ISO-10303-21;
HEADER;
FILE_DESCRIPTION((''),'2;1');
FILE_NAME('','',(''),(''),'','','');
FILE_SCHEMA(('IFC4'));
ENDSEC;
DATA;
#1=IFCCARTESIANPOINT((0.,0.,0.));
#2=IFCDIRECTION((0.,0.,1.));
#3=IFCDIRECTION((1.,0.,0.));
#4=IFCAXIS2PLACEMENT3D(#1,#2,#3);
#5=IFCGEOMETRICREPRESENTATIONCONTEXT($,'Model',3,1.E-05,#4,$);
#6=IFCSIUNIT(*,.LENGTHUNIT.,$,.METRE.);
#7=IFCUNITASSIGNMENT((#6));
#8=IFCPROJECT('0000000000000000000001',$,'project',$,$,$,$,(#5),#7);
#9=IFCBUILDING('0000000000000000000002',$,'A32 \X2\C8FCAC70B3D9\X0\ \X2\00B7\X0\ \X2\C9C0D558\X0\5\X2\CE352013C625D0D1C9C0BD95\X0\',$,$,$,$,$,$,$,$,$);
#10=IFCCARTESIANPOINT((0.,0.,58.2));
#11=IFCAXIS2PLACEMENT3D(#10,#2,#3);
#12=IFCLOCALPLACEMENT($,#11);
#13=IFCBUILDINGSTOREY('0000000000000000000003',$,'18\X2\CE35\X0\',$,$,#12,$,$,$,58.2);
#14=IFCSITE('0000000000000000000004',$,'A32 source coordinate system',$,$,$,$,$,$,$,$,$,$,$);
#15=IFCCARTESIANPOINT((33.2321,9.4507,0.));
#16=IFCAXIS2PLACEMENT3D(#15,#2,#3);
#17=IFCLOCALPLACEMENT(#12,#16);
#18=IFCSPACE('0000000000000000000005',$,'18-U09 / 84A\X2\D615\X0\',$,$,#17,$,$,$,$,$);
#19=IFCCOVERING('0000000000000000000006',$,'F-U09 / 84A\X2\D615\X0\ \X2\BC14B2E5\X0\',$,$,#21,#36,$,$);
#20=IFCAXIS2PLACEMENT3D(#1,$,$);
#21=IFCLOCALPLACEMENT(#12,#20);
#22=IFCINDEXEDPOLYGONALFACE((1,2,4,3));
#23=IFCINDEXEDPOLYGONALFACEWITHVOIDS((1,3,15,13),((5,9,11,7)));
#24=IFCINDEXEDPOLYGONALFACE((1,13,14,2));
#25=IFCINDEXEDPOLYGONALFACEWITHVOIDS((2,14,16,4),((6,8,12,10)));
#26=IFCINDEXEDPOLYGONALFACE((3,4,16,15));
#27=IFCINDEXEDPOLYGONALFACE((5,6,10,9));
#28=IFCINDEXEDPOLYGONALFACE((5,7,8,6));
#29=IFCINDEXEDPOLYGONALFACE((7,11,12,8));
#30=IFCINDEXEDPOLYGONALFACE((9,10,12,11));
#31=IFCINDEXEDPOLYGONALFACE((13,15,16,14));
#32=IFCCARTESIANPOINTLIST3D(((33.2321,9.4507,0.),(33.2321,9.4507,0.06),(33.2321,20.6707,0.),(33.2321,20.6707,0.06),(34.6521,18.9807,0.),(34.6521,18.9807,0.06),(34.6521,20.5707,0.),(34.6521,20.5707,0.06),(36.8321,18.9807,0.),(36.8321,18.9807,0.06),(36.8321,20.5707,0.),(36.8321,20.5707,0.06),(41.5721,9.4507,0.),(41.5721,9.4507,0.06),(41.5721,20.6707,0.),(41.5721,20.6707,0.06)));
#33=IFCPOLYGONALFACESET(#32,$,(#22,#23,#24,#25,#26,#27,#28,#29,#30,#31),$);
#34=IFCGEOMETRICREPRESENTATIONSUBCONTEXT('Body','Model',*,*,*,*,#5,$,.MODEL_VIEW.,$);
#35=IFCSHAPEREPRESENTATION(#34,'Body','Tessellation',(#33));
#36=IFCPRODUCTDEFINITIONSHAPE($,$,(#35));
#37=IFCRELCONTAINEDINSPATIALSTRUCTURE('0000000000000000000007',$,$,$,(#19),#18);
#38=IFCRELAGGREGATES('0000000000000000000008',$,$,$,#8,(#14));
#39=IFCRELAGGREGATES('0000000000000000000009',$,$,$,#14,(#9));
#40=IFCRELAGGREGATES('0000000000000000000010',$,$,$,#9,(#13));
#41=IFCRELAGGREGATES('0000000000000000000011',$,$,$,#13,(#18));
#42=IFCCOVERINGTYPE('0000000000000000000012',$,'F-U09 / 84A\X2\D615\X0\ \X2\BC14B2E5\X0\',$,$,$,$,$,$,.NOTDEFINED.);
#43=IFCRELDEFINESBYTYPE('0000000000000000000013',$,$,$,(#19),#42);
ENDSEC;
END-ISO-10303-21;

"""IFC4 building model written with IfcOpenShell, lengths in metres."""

from ifc_helpers import new_model, si_unit, frame, origin, origin_with_axes, place, context, subcontext, project, spatial, polyline, outline, extrude, source, transform, mapped, type_object, type_shapes, element, save


model = new_model("IFC4")

# Units and contexts
model_context = context("Model", 3, precision=1e-05, world=origin_with_axes())
body_context = subcontext(model_context, "Body", "Model", "MODEL_VIEW")
ifc_project = project(units=[si_unit("LENGTHUNIT", "METRE")], contexts=[model_context])

# Site, building, storey, space
storey_placement = place(None, frame((0.0, 0.0, 58.2), z_axis=(0.0, 0.0, 1.0), x_axis=(1.0, 0.0, 0.0)))
space_placement = place(storey_placement, frame((33.2321, 9.4507, 0.0), z_axis=(0.0, 0.0, 1.0), x_axis=(1.0, 0.0, 0.0)))
site = spatial("IfcSite", under=ifc_project, Name="A32 source coordinate system")
building = spatial("IfcBuilding", under=site, Name="A32 주거동 · 지하5층–옥탑지붕")
storey = spatial("IfcBuildingStorey", under=building, at=storey_placement, Name="18층", Elevation=58.2)
space = spatial("IfcSpace", under=storey, at=space_placement, Name="18-U09 / 84A형")

# Covering
covering_type_1 = type_object("IfcCoveringType", Name="F-U09 / 84A형 바닥", PredefinedType="NOTDEFINED")
shared_shape_1 = source(origin(), body_context, "Body", "SweptSolid", [
    extrude(outline(polyline([(0.0, 0.0), (0.0, 11.22), (8.34, 11.22), (8.34, 0.0), (0.0, 0.0)]), holes=[polyline([(1.42, 11.12), (1.42, 9.53), (3.6, 9.53), (3.6, 11.12), (1.42, 11.12)])]), origin(), (0.0, 0.0, 1.0), 0.06),
])
type_shapes(covering_type_1, [shared_shape_1])
covering_1_placement = place(space_placement, origin_with_axes())
element("IfcCovering", 1, at=covering_1_placement, inside=space, type_object=covering_type_1, Name="F-U09 / 84A형 바닥", context=body_context, shape_type="MappedRepresentation", body=[
    mapped(shared_shape_1, transform((0.0, 0.0, 0.0), scale=1.0)),
])

save(model, "model.ifc")
